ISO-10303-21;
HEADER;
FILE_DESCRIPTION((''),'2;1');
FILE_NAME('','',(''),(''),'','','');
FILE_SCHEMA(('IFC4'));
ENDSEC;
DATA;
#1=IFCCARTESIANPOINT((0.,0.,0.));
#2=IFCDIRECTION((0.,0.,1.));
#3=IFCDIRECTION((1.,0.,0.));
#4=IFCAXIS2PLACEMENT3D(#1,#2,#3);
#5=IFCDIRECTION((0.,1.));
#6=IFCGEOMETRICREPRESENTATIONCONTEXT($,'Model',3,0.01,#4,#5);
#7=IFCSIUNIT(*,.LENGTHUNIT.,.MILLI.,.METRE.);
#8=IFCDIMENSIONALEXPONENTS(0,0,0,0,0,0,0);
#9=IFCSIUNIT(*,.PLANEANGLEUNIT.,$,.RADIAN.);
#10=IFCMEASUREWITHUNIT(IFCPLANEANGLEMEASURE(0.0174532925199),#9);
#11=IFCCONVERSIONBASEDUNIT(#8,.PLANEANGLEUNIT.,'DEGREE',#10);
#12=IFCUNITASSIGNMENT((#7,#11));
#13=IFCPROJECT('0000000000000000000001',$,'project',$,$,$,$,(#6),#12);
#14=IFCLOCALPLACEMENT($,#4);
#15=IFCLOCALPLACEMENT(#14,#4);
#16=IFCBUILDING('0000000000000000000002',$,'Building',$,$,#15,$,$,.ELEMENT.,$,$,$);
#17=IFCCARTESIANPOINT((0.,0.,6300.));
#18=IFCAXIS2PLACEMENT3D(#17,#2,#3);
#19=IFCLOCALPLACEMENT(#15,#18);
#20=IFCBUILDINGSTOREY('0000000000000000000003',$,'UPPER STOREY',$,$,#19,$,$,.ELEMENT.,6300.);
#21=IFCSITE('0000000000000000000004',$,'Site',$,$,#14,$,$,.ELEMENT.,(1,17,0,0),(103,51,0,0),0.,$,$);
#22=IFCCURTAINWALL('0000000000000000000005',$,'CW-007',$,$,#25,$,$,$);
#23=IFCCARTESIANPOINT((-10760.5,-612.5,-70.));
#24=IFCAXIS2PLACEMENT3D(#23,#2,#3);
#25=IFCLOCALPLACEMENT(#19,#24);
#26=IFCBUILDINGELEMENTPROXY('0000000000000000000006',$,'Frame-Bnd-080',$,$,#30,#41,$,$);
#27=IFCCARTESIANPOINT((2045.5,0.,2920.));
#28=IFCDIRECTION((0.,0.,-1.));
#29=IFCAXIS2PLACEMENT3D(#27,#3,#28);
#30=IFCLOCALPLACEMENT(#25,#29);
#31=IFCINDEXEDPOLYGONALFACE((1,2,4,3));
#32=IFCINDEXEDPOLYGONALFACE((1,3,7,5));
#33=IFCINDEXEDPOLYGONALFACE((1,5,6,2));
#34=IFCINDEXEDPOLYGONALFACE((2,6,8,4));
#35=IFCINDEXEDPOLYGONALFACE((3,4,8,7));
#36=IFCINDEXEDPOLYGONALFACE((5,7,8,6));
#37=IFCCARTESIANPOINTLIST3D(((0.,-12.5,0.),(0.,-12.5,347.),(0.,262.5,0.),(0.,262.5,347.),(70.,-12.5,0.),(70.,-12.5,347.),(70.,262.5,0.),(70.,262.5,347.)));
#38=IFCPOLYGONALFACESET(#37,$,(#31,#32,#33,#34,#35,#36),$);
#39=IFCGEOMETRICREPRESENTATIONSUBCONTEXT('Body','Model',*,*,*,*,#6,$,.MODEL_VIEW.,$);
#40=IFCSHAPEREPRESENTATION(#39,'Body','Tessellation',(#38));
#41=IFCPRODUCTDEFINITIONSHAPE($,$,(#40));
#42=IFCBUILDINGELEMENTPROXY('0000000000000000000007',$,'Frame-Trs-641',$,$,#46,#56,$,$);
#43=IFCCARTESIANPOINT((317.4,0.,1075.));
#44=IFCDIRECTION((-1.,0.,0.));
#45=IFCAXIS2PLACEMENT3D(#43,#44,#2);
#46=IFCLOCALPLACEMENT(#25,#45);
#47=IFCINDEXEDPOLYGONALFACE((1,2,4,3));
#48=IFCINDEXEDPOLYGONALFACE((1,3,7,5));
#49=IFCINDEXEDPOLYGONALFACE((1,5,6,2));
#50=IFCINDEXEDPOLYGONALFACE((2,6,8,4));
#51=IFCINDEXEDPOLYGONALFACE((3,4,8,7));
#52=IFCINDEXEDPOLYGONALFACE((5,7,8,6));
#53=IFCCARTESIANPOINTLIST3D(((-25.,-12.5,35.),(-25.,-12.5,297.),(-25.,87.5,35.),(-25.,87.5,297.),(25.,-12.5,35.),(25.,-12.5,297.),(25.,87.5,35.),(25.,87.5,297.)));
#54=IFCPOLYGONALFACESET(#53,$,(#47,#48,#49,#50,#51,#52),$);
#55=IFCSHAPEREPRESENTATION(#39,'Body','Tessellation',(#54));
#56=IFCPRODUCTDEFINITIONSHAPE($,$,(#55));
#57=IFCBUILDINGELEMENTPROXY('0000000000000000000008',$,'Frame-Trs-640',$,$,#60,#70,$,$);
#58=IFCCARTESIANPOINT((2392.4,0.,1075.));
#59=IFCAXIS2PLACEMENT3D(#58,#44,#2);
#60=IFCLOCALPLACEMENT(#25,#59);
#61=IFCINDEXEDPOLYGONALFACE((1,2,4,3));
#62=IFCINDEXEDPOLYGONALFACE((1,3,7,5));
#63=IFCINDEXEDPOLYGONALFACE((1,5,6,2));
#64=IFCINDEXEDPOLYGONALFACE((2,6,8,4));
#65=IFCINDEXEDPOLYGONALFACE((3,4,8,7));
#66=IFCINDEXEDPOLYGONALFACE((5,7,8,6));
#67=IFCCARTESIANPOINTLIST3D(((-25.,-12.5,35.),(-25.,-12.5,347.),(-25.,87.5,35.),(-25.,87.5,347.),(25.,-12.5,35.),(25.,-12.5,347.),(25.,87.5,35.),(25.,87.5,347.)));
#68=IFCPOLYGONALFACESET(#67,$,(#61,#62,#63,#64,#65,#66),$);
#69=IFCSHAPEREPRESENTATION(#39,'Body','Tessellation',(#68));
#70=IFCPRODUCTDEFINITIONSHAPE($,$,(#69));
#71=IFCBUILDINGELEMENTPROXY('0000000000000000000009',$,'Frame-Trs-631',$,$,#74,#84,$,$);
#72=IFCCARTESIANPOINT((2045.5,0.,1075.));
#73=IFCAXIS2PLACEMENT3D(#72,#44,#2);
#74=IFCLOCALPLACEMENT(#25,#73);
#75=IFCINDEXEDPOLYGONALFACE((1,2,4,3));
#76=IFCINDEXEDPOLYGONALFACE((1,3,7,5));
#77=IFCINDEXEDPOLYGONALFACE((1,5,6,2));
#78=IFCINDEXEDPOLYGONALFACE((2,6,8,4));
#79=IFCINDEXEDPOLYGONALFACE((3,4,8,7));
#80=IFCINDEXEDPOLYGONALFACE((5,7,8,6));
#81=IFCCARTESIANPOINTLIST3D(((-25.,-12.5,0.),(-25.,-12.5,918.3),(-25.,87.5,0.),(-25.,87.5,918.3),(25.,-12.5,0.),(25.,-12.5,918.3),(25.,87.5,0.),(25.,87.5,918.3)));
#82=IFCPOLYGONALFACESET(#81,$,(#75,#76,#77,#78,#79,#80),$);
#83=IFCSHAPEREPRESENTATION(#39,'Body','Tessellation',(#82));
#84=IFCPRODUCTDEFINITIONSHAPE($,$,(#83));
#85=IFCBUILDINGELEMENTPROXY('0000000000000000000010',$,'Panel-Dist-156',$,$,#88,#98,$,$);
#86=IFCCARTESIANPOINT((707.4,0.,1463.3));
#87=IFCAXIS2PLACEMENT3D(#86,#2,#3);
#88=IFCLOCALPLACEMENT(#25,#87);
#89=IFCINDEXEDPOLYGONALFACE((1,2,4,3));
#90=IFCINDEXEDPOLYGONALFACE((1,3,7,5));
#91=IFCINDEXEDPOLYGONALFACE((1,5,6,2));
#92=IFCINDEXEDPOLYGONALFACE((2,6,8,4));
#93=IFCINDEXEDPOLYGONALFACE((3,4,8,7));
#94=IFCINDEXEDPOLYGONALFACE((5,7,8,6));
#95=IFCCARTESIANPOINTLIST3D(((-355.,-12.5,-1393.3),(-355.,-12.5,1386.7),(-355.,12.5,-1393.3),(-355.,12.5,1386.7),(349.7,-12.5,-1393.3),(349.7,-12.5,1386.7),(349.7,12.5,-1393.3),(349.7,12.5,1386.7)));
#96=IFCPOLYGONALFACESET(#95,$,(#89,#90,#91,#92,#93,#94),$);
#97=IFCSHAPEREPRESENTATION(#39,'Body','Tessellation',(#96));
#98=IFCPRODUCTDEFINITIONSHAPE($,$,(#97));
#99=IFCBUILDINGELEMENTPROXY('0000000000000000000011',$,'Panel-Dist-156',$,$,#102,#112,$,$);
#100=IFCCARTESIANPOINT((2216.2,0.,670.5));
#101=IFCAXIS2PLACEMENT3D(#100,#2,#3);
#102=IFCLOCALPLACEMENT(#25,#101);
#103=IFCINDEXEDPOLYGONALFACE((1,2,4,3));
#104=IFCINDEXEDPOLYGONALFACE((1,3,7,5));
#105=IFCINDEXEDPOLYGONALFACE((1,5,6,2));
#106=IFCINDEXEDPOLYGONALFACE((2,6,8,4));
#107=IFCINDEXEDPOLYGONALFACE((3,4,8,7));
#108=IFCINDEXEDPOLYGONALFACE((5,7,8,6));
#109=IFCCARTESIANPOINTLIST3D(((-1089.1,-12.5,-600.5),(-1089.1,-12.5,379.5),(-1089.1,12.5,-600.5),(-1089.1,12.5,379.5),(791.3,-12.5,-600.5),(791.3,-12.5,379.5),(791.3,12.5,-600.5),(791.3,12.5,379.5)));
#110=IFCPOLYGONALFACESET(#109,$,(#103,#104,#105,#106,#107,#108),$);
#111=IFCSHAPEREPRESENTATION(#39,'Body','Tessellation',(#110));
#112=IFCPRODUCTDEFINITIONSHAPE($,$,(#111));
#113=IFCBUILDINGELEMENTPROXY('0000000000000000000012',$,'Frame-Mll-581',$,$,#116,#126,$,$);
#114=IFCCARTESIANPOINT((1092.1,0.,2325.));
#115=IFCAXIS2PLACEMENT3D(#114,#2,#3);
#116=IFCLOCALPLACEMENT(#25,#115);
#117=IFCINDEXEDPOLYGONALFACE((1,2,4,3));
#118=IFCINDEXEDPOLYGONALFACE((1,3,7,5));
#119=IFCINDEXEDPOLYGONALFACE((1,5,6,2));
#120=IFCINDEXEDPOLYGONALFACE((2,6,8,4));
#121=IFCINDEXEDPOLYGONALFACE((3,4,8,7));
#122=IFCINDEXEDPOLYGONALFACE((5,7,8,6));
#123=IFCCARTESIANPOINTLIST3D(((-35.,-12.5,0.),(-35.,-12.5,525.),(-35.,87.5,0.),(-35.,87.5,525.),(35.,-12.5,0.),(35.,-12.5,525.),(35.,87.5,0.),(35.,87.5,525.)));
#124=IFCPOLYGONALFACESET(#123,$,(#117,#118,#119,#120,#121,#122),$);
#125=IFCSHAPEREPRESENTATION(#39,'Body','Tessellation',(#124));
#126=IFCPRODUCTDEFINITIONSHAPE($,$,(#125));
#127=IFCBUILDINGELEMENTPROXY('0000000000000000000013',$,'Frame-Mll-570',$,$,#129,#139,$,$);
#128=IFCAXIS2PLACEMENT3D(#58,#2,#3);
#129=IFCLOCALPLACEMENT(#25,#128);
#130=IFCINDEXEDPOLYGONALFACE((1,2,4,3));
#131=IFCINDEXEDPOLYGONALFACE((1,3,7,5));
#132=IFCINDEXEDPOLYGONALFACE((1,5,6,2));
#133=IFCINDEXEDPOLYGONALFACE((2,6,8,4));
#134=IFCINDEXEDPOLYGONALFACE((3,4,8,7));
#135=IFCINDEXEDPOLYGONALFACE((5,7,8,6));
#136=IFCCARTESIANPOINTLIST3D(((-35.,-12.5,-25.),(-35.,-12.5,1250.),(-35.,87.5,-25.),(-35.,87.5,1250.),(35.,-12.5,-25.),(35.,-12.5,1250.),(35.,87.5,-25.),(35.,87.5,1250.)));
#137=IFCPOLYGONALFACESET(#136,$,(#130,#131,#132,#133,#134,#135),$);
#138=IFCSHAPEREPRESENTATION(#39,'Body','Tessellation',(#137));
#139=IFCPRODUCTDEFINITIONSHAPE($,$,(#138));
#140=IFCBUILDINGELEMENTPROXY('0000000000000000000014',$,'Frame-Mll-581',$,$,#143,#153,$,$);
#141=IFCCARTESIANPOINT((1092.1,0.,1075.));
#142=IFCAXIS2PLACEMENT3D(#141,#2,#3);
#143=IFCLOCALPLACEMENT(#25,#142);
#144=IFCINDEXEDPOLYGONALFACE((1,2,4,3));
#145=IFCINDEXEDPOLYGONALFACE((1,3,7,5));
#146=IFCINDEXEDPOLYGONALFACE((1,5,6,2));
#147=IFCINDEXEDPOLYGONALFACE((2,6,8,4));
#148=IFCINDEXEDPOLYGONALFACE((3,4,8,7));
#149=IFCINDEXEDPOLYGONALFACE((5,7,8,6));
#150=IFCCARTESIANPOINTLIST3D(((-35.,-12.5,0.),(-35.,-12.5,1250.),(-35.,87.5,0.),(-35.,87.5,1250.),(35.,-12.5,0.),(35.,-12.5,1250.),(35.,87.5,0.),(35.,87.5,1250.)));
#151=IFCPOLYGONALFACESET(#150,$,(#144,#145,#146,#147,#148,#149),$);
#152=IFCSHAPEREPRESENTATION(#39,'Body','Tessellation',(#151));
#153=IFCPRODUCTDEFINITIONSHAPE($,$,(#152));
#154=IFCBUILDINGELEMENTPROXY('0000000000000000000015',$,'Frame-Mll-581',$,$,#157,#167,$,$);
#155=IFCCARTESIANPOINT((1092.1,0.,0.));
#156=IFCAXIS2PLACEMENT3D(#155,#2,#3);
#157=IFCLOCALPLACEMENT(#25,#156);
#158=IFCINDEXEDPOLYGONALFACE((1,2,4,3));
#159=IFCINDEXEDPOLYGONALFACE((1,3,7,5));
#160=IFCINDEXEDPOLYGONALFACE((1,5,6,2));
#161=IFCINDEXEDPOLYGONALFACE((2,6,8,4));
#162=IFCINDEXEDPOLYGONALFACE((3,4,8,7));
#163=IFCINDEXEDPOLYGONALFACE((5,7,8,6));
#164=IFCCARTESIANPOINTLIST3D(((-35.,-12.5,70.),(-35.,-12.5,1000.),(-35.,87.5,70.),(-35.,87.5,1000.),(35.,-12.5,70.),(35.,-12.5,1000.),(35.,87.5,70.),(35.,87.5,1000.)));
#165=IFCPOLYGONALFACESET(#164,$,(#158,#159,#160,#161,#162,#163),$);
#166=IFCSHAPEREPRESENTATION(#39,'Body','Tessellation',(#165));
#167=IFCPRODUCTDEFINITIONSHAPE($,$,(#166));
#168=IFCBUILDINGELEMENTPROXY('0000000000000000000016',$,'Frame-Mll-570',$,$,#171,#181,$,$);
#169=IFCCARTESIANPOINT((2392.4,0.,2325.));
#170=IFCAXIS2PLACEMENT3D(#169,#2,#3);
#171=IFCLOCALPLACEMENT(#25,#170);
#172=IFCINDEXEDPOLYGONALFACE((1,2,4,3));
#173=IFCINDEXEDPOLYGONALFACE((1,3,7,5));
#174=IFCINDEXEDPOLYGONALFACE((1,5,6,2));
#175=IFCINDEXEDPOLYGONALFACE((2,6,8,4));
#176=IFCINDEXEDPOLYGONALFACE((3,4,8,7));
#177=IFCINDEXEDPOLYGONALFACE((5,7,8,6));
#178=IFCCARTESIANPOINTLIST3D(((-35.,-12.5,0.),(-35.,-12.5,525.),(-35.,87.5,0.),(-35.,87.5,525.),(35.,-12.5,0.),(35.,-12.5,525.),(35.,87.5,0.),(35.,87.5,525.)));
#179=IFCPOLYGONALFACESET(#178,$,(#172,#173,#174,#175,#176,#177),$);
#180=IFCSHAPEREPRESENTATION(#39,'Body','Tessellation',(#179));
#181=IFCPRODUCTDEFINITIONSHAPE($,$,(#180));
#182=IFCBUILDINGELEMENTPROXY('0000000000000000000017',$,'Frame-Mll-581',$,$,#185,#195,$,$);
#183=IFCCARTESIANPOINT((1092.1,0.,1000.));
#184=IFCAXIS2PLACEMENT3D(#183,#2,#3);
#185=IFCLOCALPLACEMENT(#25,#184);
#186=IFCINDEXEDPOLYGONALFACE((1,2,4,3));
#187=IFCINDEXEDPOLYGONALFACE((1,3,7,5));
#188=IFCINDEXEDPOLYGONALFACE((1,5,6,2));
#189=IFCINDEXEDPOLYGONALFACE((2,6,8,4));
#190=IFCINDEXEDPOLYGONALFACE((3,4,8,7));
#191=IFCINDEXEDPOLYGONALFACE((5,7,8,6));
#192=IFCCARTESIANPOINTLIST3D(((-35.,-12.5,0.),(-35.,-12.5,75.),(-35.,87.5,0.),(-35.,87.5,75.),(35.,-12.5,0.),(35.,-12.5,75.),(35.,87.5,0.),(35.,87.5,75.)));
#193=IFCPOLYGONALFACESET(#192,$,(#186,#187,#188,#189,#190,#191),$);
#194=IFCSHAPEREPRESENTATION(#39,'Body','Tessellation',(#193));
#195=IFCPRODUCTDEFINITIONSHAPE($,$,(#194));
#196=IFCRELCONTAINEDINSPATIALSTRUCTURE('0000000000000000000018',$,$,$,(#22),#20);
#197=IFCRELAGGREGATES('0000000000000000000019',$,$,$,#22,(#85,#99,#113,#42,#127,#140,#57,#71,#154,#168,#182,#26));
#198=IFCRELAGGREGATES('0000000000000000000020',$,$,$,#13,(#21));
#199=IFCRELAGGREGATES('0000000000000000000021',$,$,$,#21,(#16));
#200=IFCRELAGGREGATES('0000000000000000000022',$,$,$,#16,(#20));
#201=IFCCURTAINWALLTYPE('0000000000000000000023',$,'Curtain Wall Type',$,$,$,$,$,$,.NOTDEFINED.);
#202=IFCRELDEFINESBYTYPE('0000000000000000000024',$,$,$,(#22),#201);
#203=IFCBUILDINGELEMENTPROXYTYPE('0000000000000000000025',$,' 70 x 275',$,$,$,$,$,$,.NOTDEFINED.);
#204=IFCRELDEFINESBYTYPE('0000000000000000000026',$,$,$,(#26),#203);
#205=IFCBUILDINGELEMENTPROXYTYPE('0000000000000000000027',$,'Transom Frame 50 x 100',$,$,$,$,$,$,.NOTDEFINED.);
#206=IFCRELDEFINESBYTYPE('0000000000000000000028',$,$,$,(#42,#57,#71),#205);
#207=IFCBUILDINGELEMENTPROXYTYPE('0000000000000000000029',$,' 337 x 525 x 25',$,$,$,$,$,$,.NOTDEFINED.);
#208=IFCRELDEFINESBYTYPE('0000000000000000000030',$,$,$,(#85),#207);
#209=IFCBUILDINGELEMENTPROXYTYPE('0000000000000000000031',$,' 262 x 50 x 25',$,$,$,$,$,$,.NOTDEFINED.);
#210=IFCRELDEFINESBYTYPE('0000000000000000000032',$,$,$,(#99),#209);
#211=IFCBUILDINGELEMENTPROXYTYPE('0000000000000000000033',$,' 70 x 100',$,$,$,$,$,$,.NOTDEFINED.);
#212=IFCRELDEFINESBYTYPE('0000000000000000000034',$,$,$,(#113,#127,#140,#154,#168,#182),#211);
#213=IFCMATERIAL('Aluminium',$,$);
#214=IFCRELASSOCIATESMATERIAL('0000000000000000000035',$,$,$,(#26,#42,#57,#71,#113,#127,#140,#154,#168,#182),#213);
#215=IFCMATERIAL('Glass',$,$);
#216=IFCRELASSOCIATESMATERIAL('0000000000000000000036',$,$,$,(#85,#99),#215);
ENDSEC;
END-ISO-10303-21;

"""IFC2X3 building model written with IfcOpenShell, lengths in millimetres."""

from ifc_helpers import new_model, entity, si_unit, converted_unit, direction, frame, origin_with_axes, place, context, subcontext, project, spatial, polyline, outline, extrude, material, type_object, element, aggregate, save


model = new_model("IFC2X3")

# Units and contexts
model_context = context("Model", 3, precision=0.01, world=origin_with_axes(), true_north=direction((0.0, 1.0)))
body_context = subcontext(model_context, "Body", "Model", "MODEL_VIEW")
ifc_project = project(units=[si_unit("LENGTHUNIT", "METRE", prefix="MILLI"), converted_unit("PLANEANGLEUNIT", "DEGREE", entity("IfcPlaneAngleMeasure", 0.0174532925199), si_unit("PLANEANGLEUNIT", "RADIAN"), dimensions=[0, 0, 0, 0, 0, 0, 0])], contexts=[model_context])

# Site, building, storey
site_placement = place(None, origin_with_axes())
site = spatial("IfcSite", under=ifc_project, at=site_placement, Name="Site", CompositionType="ELEMENT", RefLatitude=(1, 17, 0, 0), RefLongitude=(103, 51, 0, 0), RefElevation=0.0)
building_placement = place(site_placement, origin_with_axes())
building = spatial("IfcBuilding", under=site, at=building_placement, Name="Building", CompositionType="ELEMENT")
storey_placement = place(building_placement, frame((0.0, 0.0, 6300.0), z_axis=(0.0, 0.0, 1.0), x_axis=(1.0, 0.0, 0.0)))
storey = spatial("IfcBuildingStorey", under=building, at=storey_placement, Name="UPPER STOREY", CompositionType="ELEMENT", Elevation=6300.0)

# Curtain wall, building element proxies
curtain_wall_type = type_object("IfcCurtainWallType", Name="Curtain Wall Type", PredefinedType="NOTDEFINED")
curtain_wall_placement = place(storey_placement, frame((-10760.5, -612.5, -70.0), z_axis=(0.0, 0.0, 1.0), x_axis=(1.0, 0.0, 0.0)))
curtain_wall = element("IfcCurtainWall", 1, at=curtain_wall_placement, inside=storey, type_object=curtain_wall_type, Name="CW-007")
ifc_material_1 = material(Name="Aluminium")
building_element_proxy_type_1 = type_object("IfcBuildingElementProxyType", Name=" 70 x 275", PredefinedType="NOTDEFINED")
proxy_1_placement = place(curtain_wall_placement, frame((2045.5, 0.0, 2920.0), z_axis=(1.0, 0.0, 0.0), x_axis=(0.0, 0.0, -1.0)))
proxy_1 = element("IfcBuildingElementProxy", 2, at=proxy_1_placement, type_object=building_element_proxy_type_1, material=ifc_material_1, Name="Frame-Bnd-080", context=body_context, shape_type="SweptSolid", body=[
    extrude(outline(polyline([(-262.5, 70.0), (-262.5, 0.0), (12.5, 0.0), (12.5, 70.0), (-262.5, 70.0)])), frame((0.0, 0.0, 0.0), z_axis=(0.0, 0.0, 1.0), x_axis=(0.0, -1.0, 0.0)), (0.0, 0.0, 1.0), 347.0),
])
building_element_proxy_type_2 = type_object("IfcBuildingElementProxyType", Name="Transom Frame 50 x 100", PredefinedType="NOTDEFINED")
proxy_2_placement = place(curtain_wall_placement, frame((317.4, 0.0, 1075.0), z_axis=(-1.0, 0.0, 0.0), x_axis=(0.0, 0.0, 1.0)))
proxy_2 = element("IfcBuildingElementProxy", 3, at=proxy_2_placement, type_object=building_element_proxy_type_2, material=ifc_material_1, Name="Frame-Trs-641", context=body_context, shape_type="SweptSolid", body=[
    extrude(outline(polyline([(87.5, -25.0), (87.5, 25.0), (-12.5, 25.0), (-12.5, -25.0), (87.5, -25.0)])), frame((0.0, 0.0, 35.0), z_axis=(0.0, 0.0, 1.0), x_axis=(0.0, 1.0, 0.0)), (0.0, 0.0, 1.0), 262.0),
])
proxy_3_placement = place(curtain_wall_placement, frame((2392.4, 0.0, 1075.0), z_axis=(-1.0, 0.0, 0.0), x_axis=(0.0, 0.0, 1.0)))
proxy_3 = element("IfcBuildingElementProxy", 4, at=proxy_3_placement, type_object=building_element_proxy_type_2, material=ifc_material_1, Name="Frame-Trs-640", context=body_context, shape_type="SweptSolid", body=[
    extrude(outline(polyline([(87.5, -25.0), (87.5, 25.0), (-12.5, 25.0), (-12.5, -25.0), (87.5, -25.0)])), frame((0.0, 0.0, 35.0), z_axis=(0.0, 0.0, 1.0), x_axis=(0.0, 1.0, 0.0)), (0.0, 0.0, 1.0), 312.0),
])
proxy_4_placement = place(curtain_wall_placement, frame((2045.5, 0.0, 1075.0), z_axis=(-1.0, 0.0, 0.0), x_axis=(0.0, 0.0, 1.0)))
proxy_4 = element("IfcBuildingElementProxy", 5, at=proxy_4_placement, type_object=building_element_proxy_type_2, material=ifc_material_1, Name="Frame-Trs-631", context=body_context, shape_type="SweptSolid", body=[
    extrude(outline(polyline([(87.5, -25.0), (87.5, 25.0), (-12.5, 25.0), (-12.5, -25.0), (87.5, -25.0)])), frame((0.0, 0.0, 0.0), z_axis=(0.0, 0.0, 1.0), x_axis=(0.0, 1.0, 0.0)), (0.0, 0.0, 1.0), 918.3),
])
ifc_material_2 = material(Name="Glass")
building_element_proxy_type_3 = type_object("IfcBuildingElementProxyType", Name=" 337 x 525 x 25", PredefinedType="NOTDEFINED")
proxy_5_placement = place(curtain_wall_placement, frame((707.4, 0.0, 1463.3), z_axis=(0.0, 0.0, 1.0), x_axis=(1.0, 0.0, 0.0)))
proxy_5 = element("IfcBuildingElementProxy", 6, at=proxy_5_placement, type_object=building_element_proxy_type_3, material=ifc_material_2, Name="Panel-Dist-156", context=body_context, shape_type="SweptSolid", body=[
    extrude(outline(polyline([(-355.0, -1386.7), (349.7, -1386.7), (349.7, 1393.3), (-355.0, 1393.3), (-355.0, -1386.7)])), frame((0.0, -12.5, 0.0), z_axis=(0.0, 1.0, 0.0), x_axis=(1.0, 0.0, 0.0)), (0.0, 0.0, 1.0), 25.0),
])
building_element_proxy_type_4 = type_object("IfcBuildingElementProxyType", Name=" 262 x 50 x 25", PredefinedType="NOTDEFINED")
proxy_6_placement = place(curtain_wall_placement, frame((2216.2, 0.0, 670.5), z_axis=(0.0, 0.0, 1.0), x_axis=(1.0, 0.0, 0.0)))
proxy_6 = element("IfcBuildingElementProxy", 7, at=proxy_6_placement, type_object=building_element_proxy_type_4, material=ifc_material_2, Name="Panel-Dist-156", context=body_context, shape_type="SweptSolid", body=[
    extrude(outline(polyline([(-1089.1, -379.5), (791.3, -379.5), (791.3, 600.5), (-1089.1, 600.5), (-1089.1, -379.5)])), frame((0.0, -12.5, 0.0), z_axis=(0.0, 1.0, 0.0), x_axis=(1.0, 0.0, 0.0)), (0.0, 0.0, 1.0), 25.0),
])
building_element_proxy_type_5 = type_object("IfcBuildingElementProxyType", Name=" 70 x 100", PredefinedType="NOTDEFINED")
proxy_7_placement = place(curtain_wall_placement, frame((1092.1, 0.0, 2325.0), z_axis=(0.0, 0.0, 1.0), x_axis=(1.0, 0.0, 0.0)))
proxy_7 = element("IfcBuildingElementProxy", 8, at=proxy_7_placement, type_object=building_element_proxy_type_5, material=ifc_material_1, Name="Frame-Mll-581", context=body_context, shape_type="SweptSolid", body=[
    extrude(outline(polyline([(35.0, 87.5), (-35.0, 87.5), (-35.0, -12.5), (35.0, -12.5), (35.0, 87.5)])), frame((0.0, 0.0, 0.0), z_axis=(0.0, 0.0, 1.0), x_axis=(1.0, 0.0, 0.0)), (0.0, 0.0, 1.0), 525.0),
])
proxy_8_placement = place(curtain_wall_placement, frame((2392.4, 0.0, 1075.0), z_axis=(0.0, 0.0, 1.0), x_axis=(1.0, 0.0, 0.0)))
proxy_8 = element("IfcBuildingElementProxy", 9, at=proxy_8_placement, type_object=building_element_proxy_type_5, material=ifc_material_1, Name="Frame-Mll-570", context=body_context, shape_type="SweptSolid", body=[
    extrude(outline(polyline([(35.0, 87.5), (-35.0, 87.5), (-35.0, -12.5), (35.0, -12.5), (35.0, 87.5)])), frame((0.0, 0.0, -25.0), z_axis=(0.0, 0.0, 1.0), x_axis=(1.0, 0.0, 0.0)), (0.0, 0.0, 1.0), 1275.0),
])
proxy_9_placement = place(curtain_wall_placement, frame((1092.1, 0.0, 1075.0), z_axis=(0.0, 0.0, 1.0), x_axis=(1.0, 0.0, 0.0)))
proxy_9 = element("IfcBuildingElementProxy", 10, at=proxy_9_placement, type_object=building_element_proxy_type_5, material=ifc_material_1, Name="Frame-Mll-581", context=body_context, shape_type="SweptSolid", body=[
    extrude(outline(polyline([(35.0, 87.5), (-35.0, 87.5), (-35.0, -12.5), (35.0, -12.5), (35.0, 87.5)])), frame((0.0, 0.0, 0.0), z_axis=(0.0, 0.0, 1.0), x_axis=(1.0, 0.0, 0.0)), (0.0, 0.0, 1.0), 1250.0),
])
proxy_10_placement = place(curtain_wall_placement, frame((1092.1, 0.0, 0.0), z_axis=(0.0, 0.0, 1.0), x_axis=(1.0, 0.0, 0.0)))
proxy_10 = element("IfcBuildingElementProxy", 11, at=proxy_10_placement, type_object=building_element_proxy_type_5, material=ifc_material_1, Name="Frame-Mll-581", context=body_context, shape_type="SweptSolid", body=[
    extrude(outline(polyline([(35.0, 87.5), (-35.0, 87.5), (-35.0, -12.5), (35.0, -12.5), (35.0, 87.5)])), frame((0.0, 0.0, 70.0), z_axis=(0.0, 0.0, 1.0), x_axis=(1.0, 0.0, 0.0)), (0.0, 0.0, 1.0), 930.0),
])
proxy_11_placement = place(curtain_wall_placement, frame((2392.4, 0.0, 2325.0), z_axis=(0.0, 0.0, 1.0), x_axis=(1.0, 0.0, 0.0)))
proxy_11 = element("IfcBuildingElementProxy", 12, at=proxy_11_placement, type_object=building_element_proxy_type_5, material=ifc_material_1, Name="Frame-Mll-570", context=body_context, shape_type="SweptSolid", body=[
    extrude(outline(polyline([(35.0, 87.5), (-35.0, 87.5), (-35.0, -12.5), (35.0, -12.5), (35.0, 87.5)])), frame((0.0, 0.0, 0.0), z_axis=(0.0, 0.0, 1.0), x_axis=(1.0, 0.0, 0.0)), (0.0, 0.0, 1.0), 525.0),
])
proxy_12_placement = place(curtain_wall_placement, frame((1092.1, 0.0, 1000.0), z_axis=(0.0, 0.0, 1.0), x_axis=(1.0, 0.0, 0.0)))
proxy_12 = element("IfcBuildingElementProxy", 13, at=proxy_12_placement, type_object=building_element_proxy_type_5, material=ifc_material_1, Name="Frame-Mll-581", context=body_context, shape_type="SweptSolid", body=[
    extrude(outline(polyline([(35.0, 87.5), (-35.0, 87.5), (-35.0, -12.5), (35.0, -12.5), (35.0, 87.5)])), frame((0.0, 0.0, 0.0), z_axis=(0.0, 0.0, 1.0), x_axis=(1.0, 0.0, 0.0)), (0.0, 0.0, 1.0), 75.0),
])
aggregate(curtain_wall, [proxy_5, proxy_6, proxy_7, proxy_2, proxy_8, proxy_9, proxy_3, proxy_4, proxy_10, proxy_11, proxy_12, proxy_1])

save(model, "model.ifc")
